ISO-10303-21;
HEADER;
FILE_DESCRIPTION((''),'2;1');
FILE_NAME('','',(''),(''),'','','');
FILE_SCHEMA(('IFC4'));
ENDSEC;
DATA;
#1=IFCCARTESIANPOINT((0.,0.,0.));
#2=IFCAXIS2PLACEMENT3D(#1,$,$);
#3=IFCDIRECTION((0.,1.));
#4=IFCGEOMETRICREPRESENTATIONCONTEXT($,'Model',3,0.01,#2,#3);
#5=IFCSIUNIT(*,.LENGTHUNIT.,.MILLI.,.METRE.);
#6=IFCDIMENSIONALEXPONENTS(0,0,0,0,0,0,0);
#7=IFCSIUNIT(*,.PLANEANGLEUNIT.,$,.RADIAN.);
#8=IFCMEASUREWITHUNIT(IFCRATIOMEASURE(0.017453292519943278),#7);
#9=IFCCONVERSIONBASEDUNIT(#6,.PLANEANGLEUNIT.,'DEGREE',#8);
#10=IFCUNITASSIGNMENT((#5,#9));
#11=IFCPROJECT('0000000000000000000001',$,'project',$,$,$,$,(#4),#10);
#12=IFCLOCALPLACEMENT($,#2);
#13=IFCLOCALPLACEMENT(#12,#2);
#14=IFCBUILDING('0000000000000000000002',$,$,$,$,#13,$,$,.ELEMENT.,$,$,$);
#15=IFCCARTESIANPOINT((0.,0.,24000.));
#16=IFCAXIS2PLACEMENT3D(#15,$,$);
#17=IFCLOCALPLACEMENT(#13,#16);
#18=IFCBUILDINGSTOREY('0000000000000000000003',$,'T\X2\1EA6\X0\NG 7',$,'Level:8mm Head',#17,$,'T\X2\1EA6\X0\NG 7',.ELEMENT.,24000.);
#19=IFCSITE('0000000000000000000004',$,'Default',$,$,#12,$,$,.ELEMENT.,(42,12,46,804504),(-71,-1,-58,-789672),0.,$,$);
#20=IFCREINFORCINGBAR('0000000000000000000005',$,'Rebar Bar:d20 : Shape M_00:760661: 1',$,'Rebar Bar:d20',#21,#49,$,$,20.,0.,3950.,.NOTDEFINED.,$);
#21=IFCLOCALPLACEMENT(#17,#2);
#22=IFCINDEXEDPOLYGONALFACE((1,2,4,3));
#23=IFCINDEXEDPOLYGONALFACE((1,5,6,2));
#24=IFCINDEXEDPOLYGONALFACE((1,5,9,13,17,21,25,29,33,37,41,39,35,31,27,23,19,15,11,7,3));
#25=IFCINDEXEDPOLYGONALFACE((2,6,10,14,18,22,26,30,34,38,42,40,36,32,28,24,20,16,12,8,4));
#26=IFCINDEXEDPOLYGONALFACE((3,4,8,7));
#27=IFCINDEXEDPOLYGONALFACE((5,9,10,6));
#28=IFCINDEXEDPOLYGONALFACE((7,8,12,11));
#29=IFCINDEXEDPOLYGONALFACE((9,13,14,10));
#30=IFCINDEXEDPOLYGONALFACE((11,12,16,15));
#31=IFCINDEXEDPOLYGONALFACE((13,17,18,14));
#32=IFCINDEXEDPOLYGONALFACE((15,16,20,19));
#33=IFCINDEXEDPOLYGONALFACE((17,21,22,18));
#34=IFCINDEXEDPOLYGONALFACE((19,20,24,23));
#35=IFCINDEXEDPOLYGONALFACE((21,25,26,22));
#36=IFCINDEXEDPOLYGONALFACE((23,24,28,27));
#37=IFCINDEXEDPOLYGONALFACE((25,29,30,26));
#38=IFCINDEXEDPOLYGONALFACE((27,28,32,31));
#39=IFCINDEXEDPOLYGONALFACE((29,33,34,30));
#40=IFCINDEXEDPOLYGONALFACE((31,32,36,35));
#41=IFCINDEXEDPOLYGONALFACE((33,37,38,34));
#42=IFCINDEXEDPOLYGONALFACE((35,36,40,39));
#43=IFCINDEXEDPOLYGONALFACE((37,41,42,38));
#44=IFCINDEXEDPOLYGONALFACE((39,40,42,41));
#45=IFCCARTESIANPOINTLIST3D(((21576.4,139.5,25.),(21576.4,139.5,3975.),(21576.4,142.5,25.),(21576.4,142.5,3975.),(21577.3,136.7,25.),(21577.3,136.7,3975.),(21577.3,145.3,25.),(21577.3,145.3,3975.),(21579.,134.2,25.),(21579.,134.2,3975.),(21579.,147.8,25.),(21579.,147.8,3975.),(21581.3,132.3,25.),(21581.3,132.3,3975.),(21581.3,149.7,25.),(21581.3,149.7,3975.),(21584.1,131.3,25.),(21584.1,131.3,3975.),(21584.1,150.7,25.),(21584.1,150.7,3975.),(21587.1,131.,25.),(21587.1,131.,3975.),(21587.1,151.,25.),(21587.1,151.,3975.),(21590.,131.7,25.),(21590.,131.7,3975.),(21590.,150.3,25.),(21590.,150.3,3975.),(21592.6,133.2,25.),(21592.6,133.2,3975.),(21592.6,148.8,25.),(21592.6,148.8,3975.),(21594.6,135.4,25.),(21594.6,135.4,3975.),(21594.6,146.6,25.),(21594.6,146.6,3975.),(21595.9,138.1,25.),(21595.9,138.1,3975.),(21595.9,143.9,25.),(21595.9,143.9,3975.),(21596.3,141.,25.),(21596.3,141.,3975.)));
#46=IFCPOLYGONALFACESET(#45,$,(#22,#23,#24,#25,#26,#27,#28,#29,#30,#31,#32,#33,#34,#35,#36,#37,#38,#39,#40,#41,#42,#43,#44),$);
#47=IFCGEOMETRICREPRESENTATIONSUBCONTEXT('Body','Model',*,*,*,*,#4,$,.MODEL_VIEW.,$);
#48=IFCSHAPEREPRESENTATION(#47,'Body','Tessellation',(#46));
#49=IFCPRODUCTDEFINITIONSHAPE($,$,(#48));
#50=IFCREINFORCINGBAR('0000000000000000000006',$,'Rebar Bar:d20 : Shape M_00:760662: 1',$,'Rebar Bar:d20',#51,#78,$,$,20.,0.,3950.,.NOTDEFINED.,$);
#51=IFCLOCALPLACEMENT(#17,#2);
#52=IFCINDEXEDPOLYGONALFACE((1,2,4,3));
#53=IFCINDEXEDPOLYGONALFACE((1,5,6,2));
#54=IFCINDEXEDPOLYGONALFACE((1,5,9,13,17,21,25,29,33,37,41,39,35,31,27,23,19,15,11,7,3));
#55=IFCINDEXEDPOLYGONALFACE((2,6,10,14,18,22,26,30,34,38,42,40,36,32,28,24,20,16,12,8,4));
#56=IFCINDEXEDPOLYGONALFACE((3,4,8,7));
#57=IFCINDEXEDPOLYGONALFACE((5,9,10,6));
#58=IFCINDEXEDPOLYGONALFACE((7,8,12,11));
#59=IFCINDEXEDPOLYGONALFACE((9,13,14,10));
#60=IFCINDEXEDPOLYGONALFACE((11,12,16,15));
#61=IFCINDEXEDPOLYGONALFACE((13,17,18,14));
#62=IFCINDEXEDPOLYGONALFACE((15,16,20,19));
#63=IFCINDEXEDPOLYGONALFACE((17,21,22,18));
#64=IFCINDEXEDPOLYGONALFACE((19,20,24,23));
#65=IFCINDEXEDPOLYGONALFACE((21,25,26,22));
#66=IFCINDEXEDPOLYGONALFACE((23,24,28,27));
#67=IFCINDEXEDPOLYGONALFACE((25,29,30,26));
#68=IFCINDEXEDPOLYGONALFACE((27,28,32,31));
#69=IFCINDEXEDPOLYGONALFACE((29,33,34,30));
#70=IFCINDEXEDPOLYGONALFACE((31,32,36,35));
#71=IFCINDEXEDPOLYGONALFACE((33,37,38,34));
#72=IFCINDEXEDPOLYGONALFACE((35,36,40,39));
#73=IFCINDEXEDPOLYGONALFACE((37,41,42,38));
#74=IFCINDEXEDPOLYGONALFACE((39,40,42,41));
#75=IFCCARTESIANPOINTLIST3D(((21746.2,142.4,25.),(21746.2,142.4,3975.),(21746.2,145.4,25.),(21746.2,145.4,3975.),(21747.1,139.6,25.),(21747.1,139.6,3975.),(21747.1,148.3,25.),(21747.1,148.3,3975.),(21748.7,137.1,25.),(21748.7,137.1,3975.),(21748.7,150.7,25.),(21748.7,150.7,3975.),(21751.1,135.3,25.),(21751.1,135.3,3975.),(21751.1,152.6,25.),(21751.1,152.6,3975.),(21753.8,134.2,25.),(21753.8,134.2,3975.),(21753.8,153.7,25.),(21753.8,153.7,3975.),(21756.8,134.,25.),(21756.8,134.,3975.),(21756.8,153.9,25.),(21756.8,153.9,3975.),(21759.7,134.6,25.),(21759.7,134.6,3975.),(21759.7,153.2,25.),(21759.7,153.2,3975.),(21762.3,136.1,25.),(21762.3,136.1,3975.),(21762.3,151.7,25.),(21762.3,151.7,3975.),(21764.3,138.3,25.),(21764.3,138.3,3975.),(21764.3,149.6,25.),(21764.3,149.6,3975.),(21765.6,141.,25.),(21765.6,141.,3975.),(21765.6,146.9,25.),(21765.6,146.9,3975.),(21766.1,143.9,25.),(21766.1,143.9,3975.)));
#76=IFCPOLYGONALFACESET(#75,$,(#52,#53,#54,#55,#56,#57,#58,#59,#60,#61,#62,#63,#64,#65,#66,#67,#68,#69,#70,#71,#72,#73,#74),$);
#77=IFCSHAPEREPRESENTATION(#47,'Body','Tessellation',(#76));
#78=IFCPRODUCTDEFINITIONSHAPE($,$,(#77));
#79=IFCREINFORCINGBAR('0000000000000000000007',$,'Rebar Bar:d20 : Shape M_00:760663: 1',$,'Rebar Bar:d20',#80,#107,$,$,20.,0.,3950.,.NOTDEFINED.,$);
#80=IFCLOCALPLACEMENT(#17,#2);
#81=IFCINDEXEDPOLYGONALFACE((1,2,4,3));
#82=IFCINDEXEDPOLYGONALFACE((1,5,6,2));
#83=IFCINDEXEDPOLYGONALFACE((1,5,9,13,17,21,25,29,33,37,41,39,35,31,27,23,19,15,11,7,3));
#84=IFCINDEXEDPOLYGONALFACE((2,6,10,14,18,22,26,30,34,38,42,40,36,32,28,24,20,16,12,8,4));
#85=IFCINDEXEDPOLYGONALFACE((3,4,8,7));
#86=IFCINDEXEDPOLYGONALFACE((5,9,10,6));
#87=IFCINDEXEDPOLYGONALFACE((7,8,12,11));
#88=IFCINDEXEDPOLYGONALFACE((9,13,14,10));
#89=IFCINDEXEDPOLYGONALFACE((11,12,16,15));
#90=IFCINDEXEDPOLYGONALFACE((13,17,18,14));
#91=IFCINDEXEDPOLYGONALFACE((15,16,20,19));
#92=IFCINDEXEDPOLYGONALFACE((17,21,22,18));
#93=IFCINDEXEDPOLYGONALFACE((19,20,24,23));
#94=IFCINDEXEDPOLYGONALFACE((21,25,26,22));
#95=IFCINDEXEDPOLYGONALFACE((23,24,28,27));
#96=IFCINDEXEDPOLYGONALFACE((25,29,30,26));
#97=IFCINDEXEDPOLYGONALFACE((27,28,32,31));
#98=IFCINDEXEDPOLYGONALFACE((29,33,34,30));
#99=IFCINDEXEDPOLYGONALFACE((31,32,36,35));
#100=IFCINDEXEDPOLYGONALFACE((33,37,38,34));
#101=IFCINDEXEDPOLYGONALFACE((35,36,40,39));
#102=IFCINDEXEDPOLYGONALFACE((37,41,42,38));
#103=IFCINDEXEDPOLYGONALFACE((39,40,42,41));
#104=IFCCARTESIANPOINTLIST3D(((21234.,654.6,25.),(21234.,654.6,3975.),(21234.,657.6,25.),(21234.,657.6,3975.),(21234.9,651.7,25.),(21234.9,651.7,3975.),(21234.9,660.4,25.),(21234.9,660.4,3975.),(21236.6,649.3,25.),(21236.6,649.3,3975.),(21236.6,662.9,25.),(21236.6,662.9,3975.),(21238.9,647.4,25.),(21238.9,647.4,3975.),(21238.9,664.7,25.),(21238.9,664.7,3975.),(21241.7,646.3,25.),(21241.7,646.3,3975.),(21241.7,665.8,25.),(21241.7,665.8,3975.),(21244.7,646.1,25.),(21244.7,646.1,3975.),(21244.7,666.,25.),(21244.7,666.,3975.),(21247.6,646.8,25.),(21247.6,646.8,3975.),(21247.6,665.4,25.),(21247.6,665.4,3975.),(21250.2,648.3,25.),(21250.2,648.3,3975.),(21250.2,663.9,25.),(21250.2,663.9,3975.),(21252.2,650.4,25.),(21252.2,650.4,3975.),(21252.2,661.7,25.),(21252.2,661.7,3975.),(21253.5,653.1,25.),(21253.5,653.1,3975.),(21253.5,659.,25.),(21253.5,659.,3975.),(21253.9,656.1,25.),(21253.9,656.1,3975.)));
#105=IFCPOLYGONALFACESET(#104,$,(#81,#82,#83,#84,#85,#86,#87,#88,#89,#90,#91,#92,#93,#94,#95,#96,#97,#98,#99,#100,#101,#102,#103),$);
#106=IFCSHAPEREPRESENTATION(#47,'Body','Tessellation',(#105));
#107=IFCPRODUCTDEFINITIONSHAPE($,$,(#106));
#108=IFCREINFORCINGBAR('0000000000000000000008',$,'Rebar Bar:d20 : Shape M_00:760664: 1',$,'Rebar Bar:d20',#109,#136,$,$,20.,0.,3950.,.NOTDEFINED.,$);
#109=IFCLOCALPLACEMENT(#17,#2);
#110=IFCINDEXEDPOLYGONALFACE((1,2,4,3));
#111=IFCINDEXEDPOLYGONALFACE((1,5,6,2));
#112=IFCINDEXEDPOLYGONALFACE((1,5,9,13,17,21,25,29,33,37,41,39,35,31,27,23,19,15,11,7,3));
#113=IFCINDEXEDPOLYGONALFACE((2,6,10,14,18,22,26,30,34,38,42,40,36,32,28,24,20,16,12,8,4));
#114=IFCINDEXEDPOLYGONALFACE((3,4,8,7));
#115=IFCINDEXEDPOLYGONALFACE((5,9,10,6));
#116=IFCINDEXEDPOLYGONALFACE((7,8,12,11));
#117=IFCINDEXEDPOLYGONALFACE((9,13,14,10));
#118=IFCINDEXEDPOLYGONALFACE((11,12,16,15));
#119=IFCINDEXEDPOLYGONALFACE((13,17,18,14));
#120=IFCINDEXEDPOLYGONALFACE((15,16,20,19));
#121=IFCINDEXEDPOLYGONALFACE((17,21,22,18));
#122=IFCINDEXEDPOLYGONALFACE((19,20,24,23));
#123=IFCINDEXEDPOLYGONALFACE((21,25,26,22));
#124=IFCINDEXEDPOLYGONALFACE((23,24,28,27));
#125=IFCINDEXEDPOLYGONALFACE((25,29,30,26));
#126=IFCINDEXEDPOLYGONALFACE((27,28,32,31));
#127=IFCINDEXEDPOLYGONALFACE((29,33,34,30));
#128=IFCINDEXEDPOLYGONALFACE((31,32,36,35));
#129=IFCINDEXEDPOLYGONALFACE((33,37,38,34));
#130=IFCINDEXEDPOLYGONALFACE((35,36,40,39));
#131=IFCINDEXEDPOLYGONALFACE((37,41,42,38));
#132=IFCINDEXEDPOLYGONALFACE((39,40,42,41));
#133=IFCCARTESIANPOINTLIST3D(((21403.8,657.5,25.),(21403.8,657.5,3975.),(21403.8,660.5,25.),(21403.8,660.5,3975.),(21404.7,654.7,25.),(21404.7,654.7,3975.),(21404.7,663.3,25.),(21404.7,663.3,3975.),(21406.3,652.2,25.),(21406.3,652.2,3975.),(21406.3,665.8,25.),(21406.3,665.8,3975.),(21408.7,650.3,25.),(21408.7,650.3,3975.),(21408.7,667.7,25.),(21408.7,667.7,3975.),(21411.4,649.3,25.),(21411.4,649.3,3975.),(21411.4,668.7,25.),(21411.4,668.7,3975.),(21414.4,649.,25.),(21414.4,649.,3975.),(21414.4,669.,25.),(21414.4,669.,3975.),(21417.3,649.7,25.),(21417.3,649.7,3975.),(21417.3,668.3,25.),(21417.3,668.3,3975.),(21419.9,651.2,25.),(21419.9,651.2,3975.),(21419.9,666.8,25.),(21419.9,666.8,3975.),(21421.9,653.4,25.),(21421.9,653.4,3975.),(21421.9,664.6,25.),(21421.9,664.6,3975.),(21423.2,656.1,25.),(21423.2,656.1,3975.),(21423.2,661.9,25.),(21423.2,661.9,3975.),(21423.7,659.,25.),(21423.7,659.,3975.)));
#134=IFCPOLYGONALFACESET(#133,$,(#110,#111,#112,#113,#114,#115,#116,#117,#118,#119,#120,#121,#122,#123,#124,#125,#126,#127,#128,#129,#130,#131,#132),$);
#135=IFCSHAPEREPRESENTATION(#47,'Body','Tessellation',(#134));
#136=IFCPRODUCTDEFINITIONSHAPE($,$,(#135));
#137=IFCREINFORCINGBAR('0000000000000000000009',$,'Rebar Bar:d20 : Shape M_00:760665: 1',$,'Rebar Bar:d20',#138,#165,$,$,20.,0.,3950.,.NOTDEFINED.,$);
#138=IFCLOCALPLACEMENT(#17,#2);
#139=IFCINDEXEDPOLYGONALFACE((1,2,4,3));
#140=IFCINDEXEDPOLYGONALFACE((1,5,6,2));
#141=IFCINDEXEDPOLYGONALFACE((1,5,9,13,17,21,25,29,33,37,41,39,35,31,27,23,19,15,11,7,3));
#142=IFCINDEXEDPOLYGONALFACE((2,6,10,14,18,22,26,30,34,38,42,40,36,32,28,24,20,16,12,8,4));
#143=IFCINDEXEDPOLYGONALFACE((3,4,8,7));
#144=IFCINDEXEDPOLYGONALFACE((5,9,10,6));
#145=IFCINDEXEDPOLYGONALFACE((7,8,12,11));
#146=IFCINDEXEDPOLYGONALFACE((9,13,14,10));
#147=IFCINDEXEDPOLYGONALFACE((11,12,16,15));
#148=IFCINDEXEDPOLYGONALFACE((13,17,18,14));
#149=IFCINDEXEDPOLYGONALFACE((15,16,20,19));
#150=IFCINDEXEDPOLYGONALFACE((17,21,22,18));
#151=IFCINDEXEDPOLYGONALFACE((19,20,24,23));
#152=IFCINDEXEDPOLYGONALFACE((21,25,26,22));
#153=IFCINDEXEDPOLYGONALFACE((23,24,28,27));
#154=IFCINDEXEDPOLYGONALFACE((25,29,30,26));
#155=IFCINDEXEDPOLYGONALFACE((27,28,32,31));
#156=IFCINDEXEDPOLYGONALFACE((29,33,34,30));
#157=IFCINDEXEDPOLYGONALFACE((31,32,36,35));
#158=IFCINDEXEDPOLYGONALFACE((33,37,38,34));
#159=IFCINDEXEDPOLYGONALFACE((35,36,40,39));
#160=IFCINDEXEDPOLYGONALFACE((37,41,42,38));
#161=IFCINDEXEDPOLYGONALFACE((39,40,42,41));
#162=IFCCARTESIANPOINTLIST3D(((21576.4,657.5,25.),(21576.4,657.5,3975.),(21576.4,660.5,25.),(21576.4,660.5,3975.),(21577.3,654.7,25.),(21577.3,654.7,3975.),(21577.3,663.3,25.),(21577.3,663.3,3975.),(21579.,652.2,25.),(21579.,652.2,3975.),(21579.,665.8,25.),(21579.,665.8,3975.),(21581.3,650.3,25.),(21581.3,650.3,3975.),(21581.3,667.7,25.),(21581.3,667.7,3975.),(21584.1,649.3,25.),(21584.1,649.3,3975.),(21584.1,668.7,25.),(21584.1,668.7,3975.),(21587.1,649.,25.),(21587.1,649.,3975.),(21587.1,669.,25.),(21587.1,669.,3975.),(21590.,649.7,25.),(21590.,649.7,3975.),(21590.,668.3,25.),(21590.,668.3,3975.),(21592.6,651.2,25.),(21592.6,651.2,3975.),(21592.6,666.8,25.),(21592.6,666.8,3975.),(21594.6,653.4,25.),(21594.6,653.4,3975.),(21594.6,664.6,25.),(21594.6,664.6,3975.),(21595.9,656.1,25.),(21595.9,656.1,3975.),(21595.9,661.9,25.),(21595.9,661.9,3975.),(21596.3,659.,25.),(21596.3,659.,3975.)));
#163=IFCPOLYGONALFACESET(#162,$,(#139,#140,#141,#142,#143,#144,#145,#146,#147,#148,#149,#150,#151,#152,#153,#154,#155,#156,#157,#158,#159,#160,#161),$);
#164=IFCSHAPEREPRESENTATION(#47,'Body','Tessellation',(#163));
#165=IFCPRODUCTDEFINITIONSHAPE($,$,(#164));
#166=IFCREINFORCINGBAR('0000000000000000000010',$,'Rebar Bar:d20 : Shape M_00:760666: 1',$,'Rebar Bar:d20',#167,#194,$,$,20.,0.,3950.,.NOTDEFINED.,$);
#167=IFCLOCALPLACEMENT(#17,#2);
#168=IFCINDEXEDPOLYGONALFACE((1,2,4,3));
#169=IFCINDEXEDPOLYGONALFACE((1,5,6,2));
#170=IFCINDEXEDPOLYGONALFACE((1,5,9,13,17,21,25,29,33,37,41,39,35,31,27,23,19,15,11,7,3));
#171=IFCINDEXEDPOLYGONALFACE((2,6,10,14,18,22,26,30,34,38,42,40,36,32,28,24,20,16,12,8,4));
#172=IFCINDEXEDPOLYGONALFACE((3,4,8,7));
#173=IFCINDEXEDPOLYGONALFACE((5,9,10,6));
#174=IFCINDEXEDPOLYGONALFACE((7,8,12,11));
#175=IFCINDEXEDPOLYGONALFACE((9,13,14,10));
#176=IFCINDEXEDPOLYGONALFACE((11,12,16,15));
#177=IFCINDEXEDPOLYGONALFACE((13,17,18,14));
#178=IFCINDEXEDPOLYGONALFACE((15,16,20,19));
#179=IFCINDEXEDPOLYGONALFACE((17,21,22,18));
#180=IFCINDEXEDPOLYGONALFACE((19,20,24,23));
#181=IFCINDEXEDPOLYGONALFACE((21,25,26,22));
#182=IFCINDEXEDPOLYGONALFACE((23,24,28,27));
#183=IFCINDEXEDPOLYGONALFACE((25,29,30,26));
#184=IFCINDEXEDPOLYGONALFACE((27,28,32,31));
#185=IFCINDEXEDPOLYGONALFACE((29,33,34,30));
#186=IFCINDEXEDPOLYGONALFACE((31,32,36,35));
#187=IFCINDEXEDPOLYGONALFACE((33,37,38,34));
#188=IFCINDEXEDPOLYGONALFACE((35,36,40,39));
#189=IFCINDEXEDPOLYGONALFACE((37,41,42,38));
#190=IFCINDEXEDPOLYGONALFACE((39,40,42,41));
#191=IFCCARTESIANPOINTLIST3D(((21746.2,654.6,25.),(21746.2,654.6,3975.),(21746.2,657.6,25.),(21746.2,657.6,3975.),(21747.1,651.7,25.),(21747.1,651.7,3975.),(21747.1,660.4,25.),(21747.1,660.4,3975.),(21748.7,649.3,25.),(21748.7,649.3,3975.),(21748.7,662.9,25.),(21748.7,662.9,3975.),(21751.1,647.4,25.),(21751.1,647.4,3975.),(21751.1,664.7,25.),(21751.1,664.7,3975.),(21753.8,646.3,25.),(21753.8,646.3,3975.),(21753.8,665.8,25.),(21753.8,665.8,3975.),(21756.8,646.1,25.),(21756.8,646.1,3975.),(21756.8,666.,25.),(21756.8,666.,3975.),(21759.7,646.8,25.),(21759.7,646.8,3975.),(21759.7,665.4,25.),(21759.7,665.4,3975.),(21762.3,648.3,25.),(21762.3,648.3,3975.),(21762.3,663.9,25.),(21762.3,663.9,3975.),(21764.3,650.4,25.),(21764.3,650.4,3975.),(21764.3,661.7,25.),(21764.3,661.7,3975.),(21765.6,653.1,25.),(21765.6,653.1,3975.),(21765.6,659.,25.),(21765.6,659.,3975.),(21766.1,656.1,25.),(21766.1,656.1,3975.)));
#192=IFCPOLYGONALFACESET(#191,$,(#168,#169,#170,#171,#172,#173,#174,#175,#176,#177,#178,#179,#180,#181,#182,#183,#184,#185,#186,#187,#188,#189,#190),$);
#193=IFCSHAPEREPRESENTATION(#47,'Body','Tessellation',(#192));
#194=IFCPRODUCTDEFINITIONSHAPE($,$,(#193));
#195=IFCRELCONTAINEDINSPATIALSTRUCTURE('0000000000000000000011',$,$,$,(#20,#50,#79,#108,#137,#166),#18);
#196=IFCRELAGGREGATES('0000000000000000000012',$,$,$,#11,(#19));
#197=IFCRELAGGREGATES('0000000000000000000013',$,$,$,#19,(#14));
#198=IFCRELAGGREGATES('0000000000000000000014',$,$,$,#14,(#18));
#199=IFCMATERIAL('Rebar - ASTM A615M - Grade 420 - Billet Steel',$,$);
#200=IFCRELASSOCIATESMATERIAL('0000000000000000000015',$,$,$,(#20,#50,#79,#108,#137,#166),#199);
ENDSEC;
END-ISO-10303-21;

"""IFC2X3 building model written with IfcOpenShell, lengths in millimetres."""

from ifc_helpers import new_model, entity, si_unit, converted_unit, direction, frame, origin, place, context, subcontext, project, spatial, material, element, save


model = new_model("IFC2X3")

# Units and contexts
model_context = context("Model", 3, precision=0.01, world=origin(), true_north=direction((0.0, 1.0)))
body_context = subcontext(model_context, "Body", "Model", "MODEL_VIEW")
ifc_project = project(units=[si_unit("LENGTHUNIT", "METRE", prefix="MILLI"), converted_unit("PLANEANGLEUNIT", "DEGREE", entity("IfcRatioMeasure", 0.017453292519943278), si_unit("PLANEANGLEUNIT", "RADIAN"), dimensions=[0, 0, 0, 0, 0, 0, 0])], contexts=[model_context])

# Site, building, storey
site_placement = place(None, origin())
site = spatial("IfcSite", under=ifc_project, at=site_placement, Name="Default", CompositionType="ELEMENT", RefLatitude=(42, 12, 46, 804504), RefLongitude=(-71, -1, -58, -789672), RefElevation=0.0)
building_placement = place(site_placement, origin())
building = spatial("IfcBuilding", under=site, at=building_placement, CompositionType="ELEMENT")
storey_placement = place(building_placement, frame((0.0, 0.0, 24000.0)))
storey = spatial("IfcBuildingStorey", under=building, at=storey_placement, Name="TẦNG 7", ObjectType="Level:8mm Head", LongName="TẦNG 7", CompositionType="ELEMENT", Elevation=24000.0)

# Reinforcing bars
ifc_material = material(Name="Rebar - ASTM A615M - Grade 420 - Billet Steel")
reinforcing_bar_1_placement = place(storey_placement, origin())
element("IfcReinforcingBar", 1, at=reinforcing_bar_1_placement, inside=storey, material=ifc_material, Name="Rebar Bar:d20 : Shape M_00:760661: 1", ObjectType="Rebar Bar:d20", BarLength=3950.0, BarRole="NOTDEFINED", CrossSectionArea=0.0, NominalDiameter=20.0, context=body_context, shape_type="AdvancedSweptSolid", body=[
    entity("IfcSweptDiskSolid", entity("IfcCompositeCurve", [entity("IfcCompositeCurveSegment", "CONTINUOUS", True, entity("IfcPolyline", [entity("IfcCartesianPoint", [21586.3, 141.0, 25.0]), entity("IfcCartesianPoint", [21586.3, 141.0, 3975.0])]))], False), 10.0, None, 0.0, 1.0),
])
reinforcing_bar_2_placement = place(storey_placement, origin())
element("IfcReinforcingBar", 2, at=reinforcing_bar_2_placement, inside=storey, material=ifc_material, Name="Rebar Bar:d20 : Shape M_00:760662: 1", ObjectType="Rebar Bar:d20", BarLength=3950.0, BarRole="NOTDEFINED", CrossSectionArea=0.0, NominalDiameter=20.0, context=body_context, shape_type="AdvancedSweptSolid", body=[
    entity("IfcSweptDiskSolid", entity("IfcCompositeCurve", [entity("IfcCompositeCurveSegment", "CONTINUOUS", True, entity("IfcPolyline", [entity("IfcCartesianPoint", [21756.1, 143.9, 25.0]), entity("IfcCartesianPoint", [21756.1, 143.9, 3975.0])]))], False), 10.0, None, 0.0, 1.0),
])
reinforcing_bar_3_placement = place(storey_placement, origin())
element("IfcReinforcingBar", 3, at=reinforcing_bar_3_placement, inside=storey, material=ifc_material, Name="Rebar Bar:d20 : Shape M_00:760663: 1", ObjectType="Rebar Bar:d20", BarLength=3950.0, BarRole="NOTDEFINED", CrossSectionArea=0.0, NominalDiameter=20.0, context=body_context, shape_type="AdvancedSweptSolid", body=[
    entity("IfcSweptDiskSolid", entity("IfcCompositeCurve", [entity("IfcCompositeCurveSegment", "CONTINUOUS", True, entity("IfcPolyline", [entity("IfcCartesianPoint", [21243.9, 656.1, 25.0]), entity("IfcCartesianPoint", [21243.9, 656.1, 3975.0])]))], False), 10.0, None, 0.0, 1.0),
])
reinforcing_bar_4_placement = place(storey_placement, origin())
element("IfcReinforcingBar", 4, at=reinforcing_bar_4_placement, inside=storey, material=ifc_material, Name="Rebar Bar:d20 : Shape M_00:760664: 1", ObjectType="Rebar Bar:d20", BarLength=3950.0, BarRole="NOTDEFINED", CrossSectionArea=0.0, NominalDiameter=20.0, context=body_context, shape_type="AdvancedSweptSolid", body=[
    entity("IfcSweptDiskSolid", entity("IfcCompositeCurve", [entity("IfcCompositeCurveSegment", "CONTINUOUS", True, entity("IfcPolyline", [entity("IfcCartesianPoint", [21413.7, 659.0, 25.0]), entity("IfcCartesianPoint", [21413.7, 659.0, 3975.0])]))], False), 10.0, None, 0.0, 1.0),
])
reinforcing_bar_5_placement = place(storey_placement, origin())
element("IfcReinforcingBar", 5, at=reinforcing_bar_5_placement, inside=storey, material=ifc_material, Name="Rebar Bar:d20 : Shape M_00:760665: 1", ObjectType="Rebar Bar:d20", BarLength=3950.0, BarRole="NOTDEFINED", CrossSectionArea=0.0, NominalDiameter=20.0, context=body_context, shape_type="AdvancedSweptSolid", body=[
    entity("IfcSweptDiskSolid", entity("IfcCompositeCurve", [entity("IfcCompositeCurveSegment", "CONTINUOUS", True, entity("IfcPolyline", [entity("IfcCartesianPoint", [21586.3, 659.0, 25.0]), entity("IfcCartesianPoint", [21586.3, 659.0, 3975.0])]))], False), 10.0, None, 0.0, 1.0),
])
reinforcing_bar_6_placement = place(storey_placement, origin())
element("IfcReinforcingBar", 6, at=reinforcing_bar_6_placement, inside=storey, material=ifc_material, Name="Rebar Bar:d20 : Shape M_00:760666: 1", ObjectType="Rebar Bar:d20", BarLength=3950.0, BarRole="NOTDEFINED", CrossSectionArea=0.0, NominalDiameter=20.0, context=body_context, shape_type="AdvancedSweptSolid", body=[
    entity("IfcSweptDiskSolid", entity("IfcCompositeCurve", [entity("IfcCompositeCurveSegment", "CONTINUOUS", True, entity("IfcPolyline", [entity("IfcCartesianPoint", [21756.1, 656.1, 25.0]), entity("IfcCartesianPoint", [21756.1, 656.1, 3975.0])]))], False), 10.0, None, 0.0, 1.0),
])

save(model, "model.ifc")
